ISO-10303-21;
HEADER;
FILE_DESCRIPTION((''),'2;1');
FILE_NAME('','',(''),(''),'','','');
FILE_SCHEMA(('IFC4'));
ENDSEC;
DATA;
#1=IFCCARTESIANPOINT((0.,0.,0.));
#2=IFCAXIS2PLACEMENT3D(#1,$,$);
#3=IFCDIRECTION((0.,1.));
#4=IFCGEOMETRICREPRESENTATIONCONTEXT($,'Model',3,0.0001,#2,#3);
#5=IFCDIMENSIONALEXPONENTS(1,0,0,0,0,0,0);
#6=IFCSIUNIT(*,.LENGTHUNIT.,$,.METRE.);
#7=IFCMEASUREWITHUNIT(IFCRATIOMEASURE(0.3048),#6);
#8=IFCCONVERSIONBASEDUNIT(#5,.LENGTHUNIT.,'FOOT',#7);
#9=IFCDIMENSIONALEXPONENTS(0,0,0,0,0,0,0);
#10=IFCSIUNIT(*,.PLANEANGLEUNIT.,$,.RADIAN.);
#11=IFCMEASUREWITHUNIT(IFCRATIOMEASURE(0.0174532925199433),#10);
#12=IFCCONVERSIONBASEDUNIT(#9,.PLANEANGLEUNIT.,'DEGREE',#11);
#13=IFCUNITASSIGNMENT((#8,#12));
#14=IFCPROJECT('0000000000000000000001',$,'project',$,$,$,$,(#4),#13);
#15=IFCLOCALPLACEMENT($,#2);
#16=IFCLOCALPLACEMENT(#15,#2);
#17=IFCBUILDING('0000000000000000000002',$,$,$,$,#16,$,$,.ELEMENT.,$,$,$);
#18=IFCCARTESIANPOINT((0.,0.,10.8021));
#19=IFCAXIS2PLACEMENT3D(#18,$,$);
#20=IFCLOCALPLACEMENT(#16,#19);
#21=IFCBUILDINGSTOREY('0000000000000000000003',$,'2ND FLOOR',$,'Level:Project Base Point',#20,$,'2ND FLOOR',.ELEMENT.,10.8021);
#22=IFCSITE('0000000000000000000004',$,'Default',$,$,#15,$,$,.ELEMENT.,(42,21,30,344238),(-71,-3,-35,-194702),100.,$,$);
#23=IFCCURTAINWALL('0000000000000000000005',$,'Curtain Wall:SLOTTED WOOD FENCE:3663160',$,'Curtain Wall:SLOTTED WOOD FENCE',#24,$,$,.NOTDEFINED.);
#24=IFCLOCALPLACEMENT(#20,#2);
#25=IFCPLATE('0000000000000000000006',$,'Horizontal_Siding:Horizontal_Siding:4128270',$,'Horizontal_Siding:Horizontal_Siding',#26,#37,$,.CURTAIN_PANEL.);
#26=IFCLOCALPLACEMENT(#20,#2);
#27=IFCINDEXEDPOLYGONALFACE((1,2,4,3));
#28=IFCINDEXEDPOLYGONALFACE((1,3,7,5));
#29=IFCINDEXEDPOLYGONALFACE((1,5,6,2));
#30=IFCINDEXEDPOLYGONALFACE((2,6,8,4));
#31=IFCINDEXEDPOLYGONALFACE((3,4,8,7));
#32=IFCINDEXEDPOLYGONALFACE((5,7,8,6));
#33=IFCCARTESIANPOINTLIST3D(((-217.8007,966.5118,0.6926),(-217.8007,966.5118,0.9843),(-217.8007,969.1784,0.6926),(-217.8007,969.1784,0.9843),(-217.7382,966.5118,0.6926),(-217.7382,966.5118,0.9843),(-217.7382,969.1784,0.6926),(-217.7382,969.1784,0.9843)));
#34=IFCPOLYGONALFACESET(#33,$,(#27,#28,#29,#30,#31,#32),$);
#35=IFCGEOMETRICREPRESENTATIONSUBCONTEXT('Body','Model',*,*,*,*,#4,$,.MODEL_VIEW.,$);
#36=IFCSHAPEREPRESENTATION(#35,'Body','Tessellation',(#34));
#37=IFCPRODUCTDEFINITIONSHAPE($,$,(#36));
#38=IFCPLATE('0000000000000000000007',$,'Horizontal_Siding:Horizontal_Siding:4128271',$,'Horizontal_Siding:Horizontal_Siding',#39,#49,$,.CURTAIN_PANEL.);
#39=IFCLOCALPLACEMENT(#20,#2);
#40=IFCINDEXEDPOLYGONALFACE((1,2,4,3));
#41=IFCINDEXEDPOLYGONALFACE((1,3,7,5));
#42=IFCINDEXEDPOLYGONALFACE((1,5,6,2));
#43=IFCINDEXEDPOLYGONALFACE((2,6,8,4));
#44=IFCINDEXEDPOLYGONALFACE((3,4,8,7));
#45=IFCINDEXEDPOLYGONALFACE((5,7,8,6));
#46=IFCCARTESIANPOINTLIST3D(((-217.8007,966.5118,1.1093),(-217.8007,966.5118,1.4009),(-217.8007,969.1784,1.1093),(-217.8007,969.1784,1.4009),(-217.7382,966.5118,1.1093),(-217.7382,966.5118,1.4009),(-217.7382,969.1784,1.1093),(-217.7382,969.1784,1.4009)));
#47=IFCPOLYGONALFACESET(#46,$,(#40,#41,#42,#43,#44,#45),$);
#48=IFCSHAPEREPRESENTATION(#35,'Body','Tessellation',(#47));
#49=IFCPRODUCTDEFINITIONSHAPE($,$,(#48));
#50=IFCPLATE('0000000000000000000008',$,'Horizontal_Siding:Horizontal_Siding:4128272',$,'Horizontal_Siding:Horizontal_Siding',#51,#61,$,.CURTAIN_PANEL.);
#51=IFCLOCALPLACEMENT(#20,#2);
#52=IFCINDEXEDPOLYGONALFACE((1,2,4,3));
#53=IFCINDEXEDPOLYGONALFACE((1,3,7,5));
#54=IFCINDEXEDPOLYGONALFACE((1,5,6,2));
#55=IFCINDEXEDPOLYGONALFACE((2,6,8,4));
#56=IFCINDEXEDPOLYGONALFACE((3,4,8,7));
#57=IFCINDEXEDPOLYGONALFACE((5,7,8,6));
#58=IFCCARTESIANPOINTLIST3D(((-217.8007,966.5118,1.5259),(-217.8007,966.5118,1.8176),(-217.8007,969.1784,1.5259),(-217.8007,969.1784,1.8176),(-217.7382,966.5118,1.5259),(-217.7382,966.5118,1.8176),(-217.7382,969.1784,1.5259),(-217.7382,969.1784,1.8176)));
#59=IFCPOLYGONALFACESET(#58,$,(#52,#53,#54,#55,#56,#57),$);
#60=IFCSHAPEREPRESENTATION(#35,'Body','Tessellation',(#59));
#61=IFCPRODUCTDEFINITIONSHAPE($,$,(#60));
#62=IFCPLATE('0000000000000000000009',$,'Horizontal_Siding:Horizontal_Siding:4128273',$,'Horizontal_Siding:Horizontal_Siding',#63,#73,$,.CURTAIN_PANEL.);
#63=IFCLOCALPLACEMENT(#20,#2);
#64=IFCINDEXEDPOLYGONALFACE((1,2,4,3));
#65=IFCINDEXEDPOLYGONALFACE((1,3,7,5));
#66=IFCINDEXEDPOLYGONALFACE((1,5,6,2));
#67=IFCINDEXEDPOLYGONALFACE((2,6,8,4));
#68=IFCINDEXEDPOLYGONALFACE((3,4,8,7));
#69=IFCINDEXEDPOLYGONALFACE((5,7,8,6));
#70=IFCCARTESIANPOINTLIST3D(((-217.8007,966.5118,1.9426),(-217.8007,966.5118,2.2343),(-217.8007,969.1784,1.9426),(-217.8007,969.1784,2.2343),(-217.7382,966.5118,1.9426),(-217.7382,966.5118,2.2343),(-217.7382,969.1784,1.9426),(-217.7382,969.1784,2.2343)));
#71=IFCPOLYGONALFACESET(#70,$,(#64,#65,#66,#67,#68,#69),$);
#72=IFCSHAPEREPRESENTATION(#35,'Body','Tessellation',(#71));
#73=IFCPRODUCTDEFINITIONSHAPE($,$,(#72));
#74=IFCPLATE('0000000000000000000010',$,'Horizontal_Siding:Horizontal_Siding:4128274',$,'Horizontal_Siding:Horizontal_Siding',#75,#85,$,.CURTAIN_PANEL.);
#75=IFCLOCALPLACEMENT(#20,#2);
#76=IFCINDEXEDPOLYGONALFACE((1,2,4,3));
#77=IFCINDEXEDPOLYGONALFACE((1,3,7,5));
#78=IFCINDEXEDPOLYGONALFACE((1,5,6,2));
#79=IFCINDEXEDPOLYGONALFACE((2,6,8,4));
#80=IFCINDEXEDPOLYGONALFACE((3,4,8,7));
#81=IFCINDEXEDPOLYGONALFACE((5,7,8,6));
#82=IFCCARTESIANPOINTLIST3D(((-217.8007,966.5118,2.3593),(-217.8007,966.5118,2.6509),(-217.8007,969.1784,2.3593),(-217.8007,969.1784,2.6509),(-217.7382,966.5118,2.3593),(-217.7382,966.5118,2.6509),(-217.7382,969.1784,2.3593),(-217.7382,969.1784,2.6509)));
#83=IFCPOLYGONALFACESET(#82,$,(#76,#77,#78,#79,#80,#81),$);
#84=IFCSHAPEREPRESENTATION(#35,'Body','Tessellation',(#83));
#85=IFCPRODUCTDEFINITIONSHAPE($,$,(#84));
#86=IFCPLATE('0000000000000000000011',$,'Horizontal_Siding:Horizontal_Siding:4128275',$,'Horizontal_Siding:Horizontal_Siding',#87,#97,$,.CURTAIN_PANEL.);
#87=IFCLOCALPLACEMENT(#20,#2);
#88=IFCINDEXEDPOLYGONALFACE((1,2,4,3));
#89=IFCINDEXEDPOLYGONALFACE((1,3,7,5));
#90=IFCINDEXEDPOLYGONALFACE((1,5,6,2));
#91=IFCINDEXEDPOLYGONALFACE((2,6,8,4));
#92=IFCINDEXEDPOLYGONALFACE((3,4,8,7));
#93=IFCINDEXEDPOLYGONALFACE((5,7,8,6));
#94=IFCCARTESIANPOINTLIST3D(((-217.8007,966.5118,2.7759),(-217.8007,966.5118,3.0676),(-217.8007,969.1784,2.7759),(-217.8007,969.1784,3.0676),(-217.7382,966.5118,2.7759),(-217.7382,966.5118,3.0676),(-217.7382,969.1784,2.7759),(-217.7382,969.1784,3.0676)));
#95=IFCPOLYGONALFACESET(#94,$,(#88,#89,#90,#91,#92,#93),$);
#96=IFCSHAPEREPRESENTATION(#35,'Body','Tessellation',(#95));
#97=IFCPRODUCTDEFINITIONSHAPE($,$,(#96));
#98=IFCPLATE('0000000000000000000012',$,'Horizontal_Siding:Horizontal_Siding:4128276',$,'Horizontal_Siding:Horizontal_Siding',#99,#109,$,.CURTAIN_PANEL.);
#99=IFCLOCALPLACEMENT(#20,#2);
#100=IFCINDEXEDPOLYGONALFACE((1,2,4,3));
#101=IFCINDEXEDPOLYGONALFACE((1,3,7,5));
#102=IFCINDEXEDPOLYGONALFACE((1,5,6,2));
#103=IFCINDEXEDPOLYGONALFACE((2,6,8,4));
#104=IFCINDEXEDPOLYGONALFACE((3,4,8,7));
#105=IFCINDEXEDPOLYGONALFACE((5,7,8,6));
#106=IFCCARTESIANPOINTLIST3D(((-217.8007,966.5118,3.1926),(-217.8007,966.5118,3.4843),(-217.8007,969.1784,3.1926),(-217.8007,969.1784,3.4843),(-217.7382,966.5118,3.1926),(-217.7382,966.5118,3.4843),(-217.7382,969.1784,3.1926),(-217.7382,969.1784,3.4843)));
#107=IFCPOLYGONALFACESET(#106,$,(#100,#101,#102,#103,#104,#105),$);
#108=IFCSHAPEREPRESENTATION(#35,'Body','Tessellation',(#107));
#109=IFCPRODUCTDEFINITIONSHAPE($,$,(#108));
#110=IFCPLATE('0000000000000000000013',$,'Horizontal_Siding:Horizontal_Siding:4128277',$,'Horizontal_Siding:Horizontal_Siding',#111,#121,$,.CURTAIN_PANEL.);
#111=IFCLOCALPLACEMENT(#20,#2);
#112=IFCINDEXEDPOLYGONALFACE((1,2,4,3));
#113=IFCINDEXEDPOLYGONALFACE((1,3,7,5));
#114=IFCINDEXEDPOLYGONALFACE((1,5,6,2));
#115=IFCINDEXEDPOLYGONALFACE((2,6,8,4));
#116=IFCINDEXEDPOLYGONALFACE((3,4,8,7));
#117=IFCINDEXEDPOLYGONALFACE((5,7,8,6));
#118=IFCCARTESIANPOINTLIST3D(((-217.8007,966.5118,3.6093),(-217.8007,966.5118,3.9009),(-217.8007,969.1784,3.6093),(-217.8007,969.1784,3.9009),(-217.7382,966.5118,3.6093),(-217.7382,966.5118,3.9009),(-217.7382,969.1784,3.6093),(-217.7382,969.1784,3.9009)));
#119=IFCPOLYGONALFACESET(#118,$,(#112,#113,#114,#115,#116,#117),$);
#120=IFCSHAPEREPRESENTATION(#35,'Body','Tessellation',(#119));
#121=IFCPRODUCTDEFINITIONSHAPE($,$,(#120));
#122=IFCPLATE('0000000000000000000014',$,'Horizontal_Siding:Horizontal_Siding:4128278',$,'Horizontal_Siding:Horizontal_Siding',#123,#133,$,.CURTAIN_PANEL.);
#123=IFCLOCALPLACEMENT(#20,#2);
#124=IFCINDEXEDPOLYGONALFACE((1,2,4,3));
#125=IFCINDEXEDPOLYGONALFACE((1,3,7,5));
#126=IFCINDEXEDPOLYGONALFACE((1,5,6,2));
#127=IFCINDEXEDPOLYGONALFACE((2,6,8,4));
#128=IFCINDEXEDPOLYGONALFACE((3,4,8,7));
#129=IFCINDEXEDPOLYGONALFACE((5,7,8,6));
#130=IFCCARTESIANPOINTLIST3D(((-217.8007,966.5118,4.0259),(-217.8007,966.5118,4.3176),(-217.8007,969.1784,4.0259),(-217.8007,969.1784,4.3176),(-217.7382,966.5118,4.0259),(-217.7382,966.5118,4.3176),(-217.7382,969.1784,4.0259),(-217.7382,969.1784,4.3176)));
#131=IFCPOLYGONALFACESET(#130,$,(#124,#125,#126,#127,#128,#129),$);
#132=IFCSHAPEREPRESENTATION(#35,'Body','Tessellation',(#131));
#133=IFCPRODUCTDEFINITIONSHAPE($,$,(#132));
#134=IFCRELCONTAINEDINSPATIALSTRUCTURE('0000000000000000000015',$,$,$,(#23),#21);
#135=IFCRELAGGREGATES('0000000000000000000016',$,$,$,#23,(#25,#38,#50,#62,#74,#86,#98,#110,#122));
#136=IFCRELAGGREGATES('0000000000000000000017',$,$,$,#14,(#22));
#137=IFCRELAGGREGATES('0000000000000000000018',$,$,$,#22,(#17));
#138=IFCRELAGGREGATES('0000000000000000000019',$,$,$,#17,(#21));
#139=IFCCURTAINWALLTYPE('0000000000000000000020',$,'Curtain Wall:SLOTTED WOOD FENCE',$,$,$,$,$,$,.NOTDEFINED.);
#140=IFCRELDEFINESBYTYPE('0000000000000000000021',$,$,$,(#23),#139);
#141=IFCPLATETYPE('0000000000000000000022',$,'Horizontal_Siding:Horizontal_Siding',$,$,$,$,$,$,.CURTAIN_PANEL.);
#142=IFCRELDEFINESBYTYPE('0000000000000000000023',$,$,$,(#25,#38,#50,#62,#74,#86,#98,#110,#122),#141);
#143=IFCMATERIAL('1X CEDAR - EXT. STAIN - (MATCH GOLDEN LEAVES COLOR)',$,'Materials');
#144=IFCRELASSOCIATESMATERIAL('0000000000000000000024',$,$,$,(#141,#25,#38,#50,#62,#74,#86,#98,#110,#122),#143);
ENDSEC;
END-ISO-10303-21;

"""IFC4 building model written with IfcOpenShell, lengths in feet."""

from ifc_helpers import new_model, entity, si_unit, converted_unit, direction, frame, origin, origin_2d_with_axis, place, context, subcontext, project, spatial, rectangle, extrude, source, transform, mapped, material, type_object, type_shapes, element, aggregate, save


model = new_model("IFC4")

# Units and contexts
model_context = context("Model", 3, precision=0.0001, world=origin(), true_north=direction((0.0, 1.0)))
body_context = subcontext(model_context, "Body", "Model", "MODEL_VIEW")
ifc_project = project(units=[converted_unit("LENGTHUNIT", "FOOT", entity("IfcRatioMeasure", 0.3048), si_unit("LENGTHUNIT", "METRE"), dimensions=[1, 0, 0, 0, 0, 0, 0]), converted_unit("PLANEANGLEUNIT", "DEGREE", entity("IfcRatioMeasure", 0.0174532925199433), si_unit("PLANEANGLEUNIT", "RADIAN"), dimensions=[0, 0, 0, 0, 0, 0, 0])], contexts=[model_context])

# Site, building, storey
site_placement = place(None, origin())
site = spatial("IfcSite", under=ifc_project, at=site_placement, Name="Default", CompositionType="ELEMENT", RefLatitude=(42, 21, 30, 344238), RefLongitude=(-71, -3, -35, -194702), RefElevation=100.0)
building_placement = place(site_placement, origin())
building = spatial("IfcBuilding", under=site, at=building_placement, CompositionType="ELEMENT")
storey_placement = place(building_placement, frame((0.0, 0.0, 10.8021)))
storey = spatial("IfcBuildingStorey", under=building, at=storey_placement, Name="2ND FLOOR", ObjectType="Level:Project Base Point", LongName="2ND FLOOR", CompositionType="ELEMENT", Elevation=10.8021)

# Curtain wall, plates
curtain_wall_type = type_object("IfcCurtainWallType", Name="Curtain Wall:SLOTTED WOOD FENCE", PredefinedType="NOTDEFINED")
curtain_wall_placement = place(storey_placement, frame((0.0, 0.0, -10.8021)))
curtain_wall = element("IfcCurtainWall", 1, at=curtain_wall_placement, inside=storey, type_object=curtain_wall_type, Name="Curtain Wall:SLOTTED WOOD FENCE:3663160", ObjectType="Curtain Wall:SLOTTED WOOD FENCE", PredefinedType="NOTDEFINED")
ifc_material_1 = material(Name="1X CEDAR - EXT. STAIN - (MATCH GOLDEN LEAVES COLOR)", Category="Materials")
plate_type = type_object("IfcPlateType", Name="Horizontal_Siding:Horizontal_Siding", PredefinedType="CURTAIN_PANEL", material=ifc_material_1)
shared_shape_1 = source(origin(), body_context, "Body", "SweptSolid", [
    extrude(rectangle(XDim=2.6667, YDim=0.0625, at=origin_2d_with_axis()), frame((1.3333, 0.0312, 0.0), z_axis=(0.0, 0.0, 1.0), x_axis=(-1.0, 0.0, 0.0)), (0.0, 0.0, 1.0), 0.2917),
])
type_shapes(plate_type, [shared_shape_1])
plate_1_placement = place(curtain_wall_placement, frame((-217.8007, 969.1784, 11.4947), z_axis=(0.0, 0.0, 1.0), x_axis=(0.0, -1.0, 0.0)))
plate_1 = element("IfcPlate", 2, at=plate_1_placement, type_object=plate_type, material=ifc_material_1, Name="Horizontal_Siding:Horizontal_Siding:4128270", ObjectType="Horizontal_Siding:Horizontal_Siding", PredefinedType="CURTAIN_PANEL", context=body_context, shape_type="MappedRepresentation", body=[
    mapped(shared_shape_1, transform((0.0, 0.0, 0.0), scale=1.0)),
])
plate_2_placement = place(curtain_wall_placement, frame((-217.8007, 969.1784, 11.9113), z_axis=(0.0, 0.0, 1.0), x_axis=(0.0, -1.0, 0.0)))
plate_2 = element("IfcPlate", 3, at=plate_2_placement, type_object=plate_type, material=ifc_material_1, Name="Horizontal_Siding:Horizontal_Siding:4128271", ObjectType="Horizontal_Siding:Horizontal_Siding", PredefinedType="CURTAIN_PANEL", context=body_context, shape_type="MappedRepresentation", body=[
    mapped(shared_shape_1, transform((0.0, 0.0, 0.0), scale=1.0)),
])
plate_3_placement = place(curtain_wall_placement, frame((-217.8007, 969.1784, 12.328), z_axis=(0.0, 0.0, 1.0), x_axis=(0.0, -1.0, 0.0)))
plate_3 = element("IfcPlate", 4, at=plate_3_placement, type_object=plate_type, material=ifc_material_1, Name="Horizontal_Siding:Horizontal_Siding:4128272", ObjectType="Horizontal_Siding:Horizontal_Siding", PredefinedType="CURTAIN_PANEL", context=body_context, shape_type="MappedRepresentation", body=[
    mapped(shared_shape_1, transform((0.0, 0.0, 0.0), scale=1.0)),
])
plate_4_placement = place(curtain_wall_placement, frame((-217.8007, 969.1784, 12.7447), z_axis=(0.0, 0.0, 1.0), x_axis=(0.0, -1.0, 0.0)))
plate_4 = element("IfcPlate", 5, at=plate_4_placement, type_object=plate_type, material=ifc_material_1, Name="Horizontal_Siding:Horizontal_Siding:4128273", ObjectType="Horizontal_Siding:Horizontal_Siding", PredefinedType="CURTAIN_PANEL", context=body_context, shape_type="MappedRepresentation", body=[
    mapped(shared_shape_1, transform((0.0, 0.0, 0.0), scale=1.0)),
])
plate_5_placement = place(curtain_wall_placement, frame((-217.8007, 969.1784, 13.1613), z_axis=(0.0, 0.0, 1.0), x_axis=(0.0, -1.0, 0.0)))
plate_5 = element("IfcPlate", 6, at=plate_5_placement, type_object=plate_type, material=ifc_material_1, Name="Horizontal_Siding:Horizontal_Siding:4128274", ObjectType="Horizontal_Siding:Horizontal_Siding", PredefinedType="CURTAIN_PANEL", context=body_context, shape_type="MappedRepresentation", body=[
    mapped(shared_shape_1, transform((0.0, 0.0, 0.0), scale=1.0)),
])
plate_6_placement = place(curtain_wall_placement, frame((-217.8007, 969.1784, 13.578), z_axis=(0.0, 0.0, 1.0), x_axis=(0.0, -1.0, 0.0)))
plate_6 = element("IfcPlate", 7, at=plate_6_placement, type_object=plate_type, material=ifc_material_1, Name="Horizontal_Siding:Horizontal_Siding:4128275", ObjectType="Horizontal_Siding:Horizontal_Siding", PredefinedType="CURTAIN_PANEL", context=body_context, shape_type="MappedRepresentation", body=[
    mapped(shared_shape_1, transform((0.0, 0.0, 0.0), scale=1.0)),
])
plate_7_placement = place(curtain_wall_placement, frame((-217.8007, 969.1784, 13.9947), z_axis=(0.0, 0.0, 1.0), x_axis=(0.0, -1.0, 0.0)))
plate_7 = element("IfcPlate", 8, at=plate_7_placement, type_object=plate_type, material=ifc_material_1, Name="Horizontal_Siding:Horizontal_Siding:4128276", ObjectType="Horizontal_Siding:Horizontal_Siding", PredefinedType="CURTAIN_PANEL", context=body_context, shape_type="MappedRepresentation", body=[
    mapped(shared_shape_1, transform((0.0, 0.0, 0.0), scale=1.0)),
])
plate_8_placement = place(curtain_wall_placement, frame((-217.8007, 969.1784, 14.4113), z_axis=(0.0, 0.0, 1.0), x_axis=(0.0, -1.0, 0.0)))
plate_8 = element("IfcPlate", 9, at=plate_8_placement, type_object=plate_type, material=ifc_material_1, Name="Horizontal_Siding:Horizontal_Siding:4128277", ObjectType="Horizontal_Siding:Horizontal_Siding", PredefinedType="CURTAIN_PANEL", context=body_context, shape_type="MappedRepresentation", body=[
    mapped(shared_shape_1, transform((0.0, 0.0, 0.0), scale=1.0)),
])
plate_9_placement = place(curtain_wall_placement, frame((-217.8007, 969.1784, 14.828), z_axis=(0.0, 0.0, 1.0), x_axis=(0.0, -1.0, 0.0)))
plate_9 = element("IfcPlate", 10, at=plate_9_placement, type_object=plate_type, material=ifc_material_1, Name="Horizontal_Siding:Horizontal_Siding:4128278", ObjectType="Horizontal_Siding:Horizontal_Siding", PredefinedType="CURTAIN_PANEL", context=body_context, shape_type="MappedRepresentation", body=[
    mapped(shared_shape_1, transform((0.0, 0.0, 0.0), scale=1.0)),
])
aggregate(curtain_wall, [plate_1, plate_2, plate_3, plate_4, plate_5, plate_6, plate_7, plate_8, plate_9])

save(model, "model.ifc")
